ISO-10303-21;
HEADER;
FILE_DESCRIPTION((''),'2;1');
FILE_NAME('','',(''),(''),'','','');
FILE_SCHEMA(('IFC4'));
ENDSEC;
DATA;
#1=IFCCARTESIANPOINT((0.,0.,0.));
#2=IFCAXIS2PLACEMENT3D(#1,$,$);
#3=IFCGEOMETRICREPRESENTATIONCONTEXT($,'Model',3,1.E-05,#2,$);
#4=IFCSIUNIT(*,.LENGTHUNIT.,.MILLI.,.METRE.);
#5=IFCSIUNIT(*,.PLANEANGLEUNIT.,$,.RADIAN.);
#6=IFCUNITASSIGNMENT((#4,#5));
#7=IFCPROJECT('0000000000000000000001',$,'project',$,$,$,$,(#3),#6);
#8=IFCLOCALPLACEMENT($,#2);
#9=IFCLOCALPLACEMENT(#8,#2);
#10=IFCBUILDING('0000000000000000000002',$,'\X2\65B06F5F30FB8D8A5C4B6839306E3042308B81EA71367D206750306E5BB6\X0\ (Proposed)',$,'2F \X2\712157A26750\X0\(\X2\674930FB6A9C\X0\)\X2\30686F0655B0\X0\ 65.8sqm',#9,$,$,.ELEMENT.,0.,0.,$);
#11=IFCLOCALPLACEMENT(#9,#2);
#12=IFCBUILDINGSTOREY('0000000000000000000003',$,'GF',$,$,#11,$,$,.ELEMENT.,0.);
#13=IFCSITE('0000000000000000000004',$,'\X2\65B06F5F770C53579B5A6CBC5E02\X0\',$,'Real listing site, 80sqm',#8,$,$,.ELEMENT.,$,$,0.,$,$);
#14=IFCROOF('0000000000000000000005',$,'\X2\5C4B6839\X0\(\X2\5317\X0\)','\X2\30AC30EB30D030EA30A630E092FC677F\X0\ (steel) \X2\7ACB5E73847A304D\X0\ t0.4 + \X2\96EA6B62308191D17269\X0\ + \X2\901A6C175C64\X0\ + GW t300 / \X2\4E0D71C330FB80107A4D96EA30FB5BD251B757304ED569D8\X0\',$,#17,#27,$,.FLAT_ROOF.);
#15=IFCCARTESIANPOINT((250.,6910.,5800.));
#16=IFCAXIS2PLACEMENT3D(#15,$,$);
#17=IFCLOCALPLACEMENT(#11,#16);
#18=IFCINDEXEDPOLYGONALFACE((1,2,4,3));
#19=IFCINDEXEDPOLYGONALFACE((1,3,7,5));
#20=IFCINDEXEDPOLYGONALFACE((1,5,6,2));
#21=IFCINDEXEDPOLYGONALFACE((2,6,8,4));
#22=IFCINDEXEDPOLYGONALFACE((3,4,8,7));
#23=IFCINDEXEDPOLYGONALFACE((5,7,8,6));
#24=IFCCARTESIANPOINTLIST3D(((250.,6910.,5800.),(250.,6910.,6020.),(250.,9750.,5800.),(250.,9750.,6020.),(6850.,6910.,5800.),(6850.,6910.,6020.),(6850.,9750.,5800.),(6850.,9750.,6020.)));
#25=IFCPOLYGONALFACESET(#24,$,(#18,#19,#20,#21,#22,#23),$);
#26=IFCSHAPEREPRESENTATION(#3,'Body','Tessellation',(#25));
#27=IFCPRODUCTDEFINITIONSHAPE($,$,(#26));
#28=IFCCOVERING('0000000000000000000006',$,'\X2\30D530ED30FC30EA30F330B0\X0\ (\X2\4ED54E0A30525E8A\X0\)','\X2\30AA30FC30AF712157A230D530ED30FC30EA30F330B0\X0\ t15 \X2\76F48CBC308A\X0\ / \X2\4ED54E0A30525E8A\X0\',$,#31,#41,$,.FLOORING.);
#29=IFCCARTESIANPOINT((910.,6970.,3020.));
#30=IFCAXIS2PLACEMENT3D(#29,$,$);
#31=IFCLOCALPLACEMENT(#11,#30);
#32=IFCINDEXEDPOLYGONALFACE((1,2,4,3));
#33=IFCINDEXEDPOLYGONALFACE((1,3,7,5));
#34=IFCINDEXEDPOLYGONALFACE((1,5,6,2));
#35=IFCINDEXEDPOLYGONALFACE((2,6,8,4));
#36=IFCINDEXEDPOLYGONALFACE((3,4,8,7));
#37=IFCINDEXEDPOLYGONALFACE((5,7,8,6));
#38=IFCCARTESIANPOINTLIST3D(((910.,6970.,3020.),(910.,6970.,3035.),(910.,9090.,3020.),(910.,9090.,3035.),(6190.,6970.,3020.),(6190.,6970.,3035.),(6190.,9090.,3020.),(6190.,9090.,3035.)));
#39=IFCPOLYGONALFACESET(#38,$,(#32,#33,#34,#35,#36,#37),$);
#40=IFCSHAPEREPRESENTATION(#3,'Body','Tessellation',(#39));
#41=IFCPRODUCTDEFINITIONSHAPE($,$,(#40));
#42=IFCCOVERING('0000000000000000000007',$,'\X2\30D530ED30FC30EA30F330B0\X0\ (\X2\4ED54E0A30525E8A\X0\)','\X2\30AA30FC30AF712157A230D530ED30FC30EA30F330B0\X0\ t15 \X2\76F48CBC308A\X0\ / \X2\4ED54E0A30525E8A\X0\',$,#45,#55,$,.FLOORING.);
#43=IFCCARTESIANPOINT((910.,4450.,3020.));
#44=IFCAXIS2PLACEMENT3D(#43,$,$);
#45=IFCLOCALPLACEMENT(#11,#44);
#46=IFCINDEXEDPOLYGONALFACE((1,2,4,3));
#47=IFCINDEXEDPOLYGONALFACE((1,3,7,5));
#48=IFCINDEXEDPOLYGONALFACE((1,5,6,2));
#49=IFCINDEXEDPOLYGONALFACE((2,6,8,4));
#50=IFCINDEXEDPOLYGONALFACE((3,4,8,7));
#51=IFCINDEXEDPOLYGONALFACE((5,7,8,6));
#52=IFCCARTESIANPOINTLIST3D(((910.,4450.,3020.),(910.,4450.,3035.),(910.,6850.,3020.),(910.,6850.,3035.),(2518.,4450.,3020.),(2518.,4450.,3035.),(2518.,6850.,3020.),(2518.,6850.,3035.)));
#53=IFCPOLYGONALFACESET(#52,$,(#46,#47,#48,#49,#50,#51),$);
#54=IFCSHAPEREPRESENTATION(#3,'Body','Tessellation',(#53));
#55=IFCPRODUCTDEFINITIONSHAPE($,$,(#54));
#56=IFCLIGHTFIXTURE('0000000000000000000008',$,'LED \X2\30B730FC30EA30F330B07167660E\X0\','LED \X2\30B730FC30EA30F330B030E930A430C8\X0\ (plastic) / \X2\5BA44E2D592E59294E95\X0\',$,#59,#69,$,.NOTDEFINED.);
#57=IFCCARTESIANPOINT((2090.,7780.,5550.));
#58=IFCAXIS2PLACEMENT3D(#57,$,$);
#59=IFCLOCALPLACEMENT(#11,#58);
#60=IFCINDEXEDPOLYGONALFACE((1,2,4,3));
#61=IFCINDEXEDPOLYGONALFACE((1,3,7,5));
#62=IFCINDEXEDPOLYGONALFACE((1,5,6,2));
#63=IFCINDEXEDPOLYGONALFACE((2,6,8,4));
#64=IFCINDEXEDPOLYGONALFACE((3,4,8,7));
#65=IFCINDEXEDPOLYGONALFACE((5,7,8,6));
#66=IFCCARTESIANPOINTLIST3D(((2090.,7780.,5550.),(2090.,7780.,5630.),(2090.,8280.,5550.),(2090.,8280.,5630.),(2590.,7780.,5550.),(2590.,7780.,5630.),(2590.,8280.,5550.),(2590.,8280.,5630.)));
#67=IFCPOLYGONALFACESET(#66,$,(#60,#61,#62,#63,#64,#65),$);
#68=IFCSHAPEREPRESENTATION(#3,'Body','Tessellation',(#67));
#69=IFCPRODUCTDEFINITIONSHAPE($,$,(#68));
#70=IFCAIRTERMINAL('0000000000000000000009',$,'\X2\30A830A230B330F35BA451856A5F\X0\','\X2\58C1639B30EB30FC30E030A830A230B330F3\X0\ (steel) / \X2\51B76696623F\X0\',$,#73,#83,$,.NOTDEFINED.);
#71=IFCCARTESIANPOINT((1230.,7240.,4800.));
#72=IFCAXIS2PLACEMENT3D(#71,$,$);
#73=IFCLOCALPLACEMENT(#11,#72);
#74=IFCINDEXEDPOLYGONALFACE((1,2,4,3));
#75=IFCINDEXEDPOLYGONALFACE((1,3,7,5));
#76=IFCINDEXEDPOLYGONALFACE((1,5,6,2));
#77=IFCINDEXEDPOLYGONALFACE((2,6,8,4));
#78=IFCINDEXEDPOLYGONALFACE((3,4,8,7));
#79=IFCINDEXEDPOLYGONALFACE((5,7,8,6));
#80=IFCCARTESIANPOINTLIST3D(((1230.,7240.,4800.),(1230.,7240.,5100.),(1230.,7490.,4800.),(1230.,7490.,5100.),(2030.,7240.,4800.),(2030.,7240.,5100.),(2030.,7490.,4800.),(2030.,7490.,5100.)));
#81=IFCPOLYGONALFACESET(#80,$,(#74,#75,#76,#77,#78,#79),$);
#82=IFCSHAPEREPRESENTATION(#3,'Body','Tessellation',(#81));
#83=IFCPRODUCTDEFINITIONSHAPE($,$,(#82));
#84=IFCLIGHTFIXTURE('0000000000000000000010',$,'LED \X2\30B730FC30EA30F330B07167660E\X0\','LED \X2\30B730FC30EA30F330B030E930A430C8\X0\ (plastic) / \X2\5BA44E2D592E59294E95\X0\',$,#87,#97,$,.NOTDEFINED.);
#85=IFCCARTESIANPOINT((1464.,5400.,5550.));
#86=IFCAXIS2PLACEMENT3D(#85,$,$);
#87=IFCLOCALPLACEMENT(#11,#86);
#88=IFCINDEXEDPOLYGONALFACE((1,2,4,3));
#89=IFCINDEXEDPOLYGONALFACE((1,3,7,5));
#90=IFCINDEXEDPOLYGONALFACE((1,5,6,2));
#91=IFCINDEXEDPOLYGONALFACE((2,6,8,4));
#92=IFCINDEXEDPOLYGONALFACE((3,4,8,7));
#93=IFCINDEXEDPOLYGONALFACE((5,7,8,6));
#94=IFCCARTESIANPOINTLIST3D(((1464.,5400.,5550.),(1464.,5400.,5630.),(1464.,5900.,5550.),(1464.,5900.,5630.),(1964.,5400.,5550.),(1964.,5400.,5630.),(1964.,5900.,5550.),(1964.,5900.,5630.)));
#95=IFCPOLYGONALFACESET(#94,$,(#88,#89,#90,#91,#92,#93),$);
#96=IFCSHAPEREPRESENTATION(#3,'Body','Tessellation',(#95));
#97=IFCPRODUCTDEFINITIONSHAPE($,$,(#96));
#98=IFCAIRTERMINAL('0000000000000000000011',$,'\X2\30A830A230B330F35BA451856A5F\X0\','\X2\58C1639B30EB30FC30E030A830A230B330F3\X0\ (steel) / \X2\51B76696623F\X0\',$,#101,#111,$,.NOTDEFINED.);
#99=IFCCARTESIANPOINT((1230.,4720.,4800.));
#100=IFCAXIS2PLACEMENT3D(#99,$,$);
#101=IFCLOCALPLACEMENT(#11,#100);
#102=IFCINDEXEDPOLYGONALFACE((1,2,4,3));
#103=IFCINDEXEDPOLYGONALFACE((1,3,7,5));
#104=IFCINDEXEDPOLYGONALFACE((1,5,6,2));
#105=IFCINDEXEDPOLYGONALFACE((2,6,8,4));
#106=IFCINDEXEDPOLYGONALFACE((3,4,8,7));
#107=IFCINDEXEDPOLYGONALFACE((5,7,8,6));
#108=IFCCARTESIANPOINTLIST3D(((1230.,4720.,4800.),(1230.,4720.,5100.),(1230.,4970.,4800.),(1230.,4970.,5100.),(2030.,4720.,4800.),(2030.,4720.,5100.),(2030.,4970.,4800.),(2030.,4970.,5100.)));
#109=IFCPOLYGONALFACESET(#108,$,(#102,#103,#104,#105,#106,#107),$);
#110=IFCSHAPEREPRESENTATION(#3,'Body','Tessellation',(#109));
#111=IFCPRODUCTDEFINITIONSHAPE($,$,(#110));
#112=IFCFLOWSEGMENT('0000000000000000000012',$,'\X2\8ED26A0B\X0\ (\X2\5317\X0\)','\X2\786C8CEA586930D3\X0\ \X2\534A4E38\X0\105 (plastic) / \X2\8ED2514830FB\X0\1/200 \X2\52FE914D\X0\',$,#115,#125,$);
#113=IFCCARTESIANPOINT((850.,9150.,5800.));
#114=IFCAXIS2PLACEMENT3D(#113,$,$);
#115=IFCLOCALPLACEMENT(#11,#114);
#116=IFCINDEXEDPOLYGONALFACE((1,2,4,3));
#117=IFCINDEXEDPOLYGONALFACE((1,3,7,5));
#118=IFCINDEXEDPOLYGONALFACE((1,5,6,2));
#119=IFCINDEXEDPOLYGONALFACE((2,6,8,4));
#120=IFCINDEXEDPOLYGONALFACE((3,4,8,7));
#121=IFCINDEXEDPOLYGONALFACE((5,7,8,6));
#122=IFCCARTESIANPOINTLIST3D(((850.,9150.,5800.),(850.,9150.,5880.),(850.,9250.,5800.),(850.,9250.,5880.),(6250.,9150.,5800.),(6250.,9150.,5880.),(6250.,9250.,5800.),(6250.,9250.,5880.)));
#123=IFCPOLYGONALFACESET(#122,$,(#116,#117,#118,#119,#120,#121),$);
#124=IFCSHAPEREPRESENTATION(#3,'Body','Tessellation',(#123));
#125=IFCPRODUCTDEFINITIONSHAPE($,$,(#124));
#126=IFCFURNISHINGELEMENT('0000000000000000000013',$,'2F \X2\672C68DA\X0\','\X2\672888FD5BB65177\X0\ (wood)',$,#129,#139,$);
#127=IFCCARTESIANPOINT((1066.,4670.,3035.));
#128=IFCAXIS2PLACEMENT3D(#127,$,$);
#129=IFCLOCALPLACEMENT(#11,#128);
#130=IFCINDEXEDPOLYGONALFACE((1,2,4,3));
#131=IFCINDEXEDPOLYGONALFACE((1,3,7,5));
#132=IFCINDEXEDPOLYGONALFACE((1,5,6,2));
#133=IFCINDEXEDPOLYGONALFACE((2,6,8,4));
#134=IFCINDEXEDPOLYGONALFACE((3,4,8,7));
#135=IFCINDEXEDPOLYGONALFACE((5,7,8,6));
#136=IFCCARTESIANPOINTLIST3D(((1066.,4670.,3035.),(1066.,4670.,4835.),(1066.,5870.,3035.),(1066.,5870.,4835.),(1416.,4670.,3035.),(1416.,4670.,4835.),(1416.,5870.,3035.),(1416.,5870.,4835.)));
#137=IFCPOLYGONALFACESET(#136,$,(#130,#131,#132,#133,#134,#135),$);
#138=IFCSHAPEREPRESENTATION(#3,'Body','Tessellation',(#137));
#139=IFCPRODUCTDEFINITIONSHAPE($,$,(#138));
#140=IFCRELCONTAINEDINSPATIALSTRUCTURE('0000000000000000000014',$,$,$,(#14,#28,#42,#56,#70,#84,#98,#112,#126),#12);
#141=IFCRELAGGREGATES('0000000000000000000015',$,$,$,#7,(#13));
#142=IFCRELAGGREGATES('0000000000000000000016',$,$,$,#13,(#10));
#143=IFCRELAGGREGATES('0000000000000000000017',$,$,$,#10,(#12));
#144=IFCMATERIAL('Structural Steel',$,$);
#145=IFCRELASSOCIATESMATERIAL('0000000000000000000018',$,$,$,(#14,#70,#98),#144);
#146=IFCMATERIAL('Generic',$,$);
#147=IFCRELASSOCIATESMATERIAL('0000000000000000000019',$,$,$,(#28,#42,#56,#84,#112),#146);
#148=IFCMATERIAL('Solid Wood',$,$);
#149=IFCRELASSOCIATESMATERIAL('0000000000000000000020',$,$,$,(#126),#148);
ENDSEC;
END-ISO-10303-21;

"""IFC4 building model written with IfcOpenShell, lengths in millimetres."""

from ifc_helpers import new_model, si_unit, frame, frame_2d, origin, place, context, project, spatial, rectangle, extrude, material, element, save


model = new_model("IFC4")

# Units and contexts
model_context = context("Model", 3, precision=1e-05, world=origin())
ifc_project = project(units=[si_unit("LENGTHUNIT", "METRE", prefix="MILLI"), si_unit("PLANEANGLEUNIT", "RADIAN")], contexts=[model_context])

# Site, building, storey
site_placement = place(None, origin())
site = spatial("IfcSite", under=ifc_project, at=site_placement, Name="新潟県南魚沼市", ObjectType="Real listing site, 80sqm", CompositionType="ELEMENT", RefElevation=0.0)
building_placement = place(site_placement, origin())
building = spatial("IfcBuilding", under=site, at=building_placement, Name="新潟・越屋根のある自然素材の家 (Proposed)", ObjectType="2F 無垢材(杉・檜)と漆喰 65.8sqm", CompositionType="ELEMENT", ElevationOfRefHeight=0.0, ElevationOfTerrain=0.0)
storey_placement = place(building_placement, origin())
storey = spatial("IfcBuildingStorey", under=building, at=storey_placement, Name="GF", CompositionType="ELEMENT", Elevation=0.0)

# Shared definitions
ifc_material_1 = material(Name="Solid Wood")

# Roof
ifc_material_2 = material(Name="Structural Steel")
for number, where, name in (
    (1, (250.0, 6910.0, 5800.0), "屋根(北)"),
):
    element("IfcRoof", number, at=place(storey_placement, frame(where)), inside=storey, material=ifc_material_2, Name=name, Description="ガルバリウム鋼板 (steel) 立平葺き t0.4 + 雪止め金物 + 通気層 + GW t300 / 不燃・耐積雪・寒冷地仕様", PredefinedType="FLAT_ROOF", context=model_context, shape_type="SweptSolid", body=[
        extrude(rectangle(XDim=6600.0, YDim=2840.0, at=frame_2d((3300.0, 1420.0))), frame((250.0, 6910.0, 5800.0)), (0.0, 0.0, 1.0), 220.0),
    ])

# Coverings
ifc_material_3 = material(Name="Generic")
covering_1_placement = place(storey_placement, frame((910.0, 6970.0, 3020.0)))
element("IfcCovering", 2, at=covering_1_placement, inside=storey, material=ifc_material_3, Name="フローリング (仕上げ床)", Description="オーク無垢フローリング t15 直貼り / 仕上げ床", PredefinedType="FLOORING", context=model_context, shape_type="SweptSolid", body=[
    extrude(rectangle(XDim=5280.0, YDim=2120.0, at=frame_2d((2640.0, 1060.0))), frame((910.0, 6970.0, 3020.0)), (0.0, 0.0, 1.0), 15.0),
])
covering_2_placement = place(storey_placement, frame((910.0, 4450.0, 3020.0)))
element("IfcCovering", 3, at=covering_2_placement, inside=storey, material=ifc_material_3, Name="フローリング (仕上げ床)", Description="オーク無垢フローリング t15 直貼り / 仕上げ床", PredefinedType="FLOORING", context=model_context, shape_type="SweptSolid", body=[
    extrude(rectangle(XDim=1608.0, YDim=2400.0, at=frame_2d((804.0, 1200.0))), frame((910.0, 4450.0, 3020.0)), (0.0, 0.0, 1.0), 15.0),
])

# Light fixture
light_fixture_1_placement = place(storey_placement, frame((2090.0, 7780.0, 5550.0)))
element("IfcLightFixture", 4, at=light_fixture_1_placement, inside=storey, material=ifc_material_3, Name="LED シーリング照明", Description="LED シーリングライト (plastic) / 室中央天井", PredefinedType="NOTDEFINED", context=model_context, shape_type="SweptSolid", body=[
    extrude(rectangle(XDim=500.0, YDim=500.0, at=frame_2d((250.0, 250.0))), frame((2090.0, 7780.0, 5550.0)), (0.0, 0.0, 1.0), 80.0),
])

# Air terminal
air_terminal_1_placement = place(storey_placement, frame((1230.0, 7240.0, 4800.0)))
element("IfcAirTerminal", 5, at=air_terminal_1_placement, inside=storey, material=ifc_material_2, Name="エアコン室内機", Description="壁掛ルームエアコン (steel) / 冷暖房", PredefinedType="NOTDEFINED", context=model_context, shape_type="SweptSolid", body=[
    extrude(rectangle(XDim=800.0, YDim=250.0, at=frame_2d((400.0, 125.0))), frame((1230.0, 7240.0, 4800.0)), (0.0, 0.0, 1.0), 300.0),
])

# Light fixture
light_fixture_2_placement = place(storey_placement, frame((1464.0, 5400.0, 5550.0)))
element("IfcLightFixture", 6, at=light_fixture_2_placement, inside=storey, material=ifc_material_3, Name="LED シーリング照明", Description="LED シーリングライト (plastic) / 室中央天井", PredefinedType="NOTDEFINED", context=model_context, shape_type="SweptSolid", body=[
    extrude(rectangle(XDim=500.0, YDim=500.0, at=frame_2d((250.0, 250.0))), frame((1464.0, 5400.0, 5550.0)), (0.0, 0.0, 1.0), 80.0),
])

# Air terminal
air_terminal_2_placement = place(storey_placement, frame((1230.0, 4720.0, 4800.0)))
element("IfcAirTerminal", 7, at=air_terminal_2_placement, inside=storey, material=ifc_material_2, Name="エアコン室内機", Description="壁掛ルームエアコン (steel) / 冷暖房", PredefinedType="NOTDEFINED", context=model_context, shape_type="SweptSolid", body=[
    extrude(rectangle(XDim=800.0, YDim=250.0, at=frame_2d((400.0, 125.0))), frame((1230.0, 4720.0, 4800.0)), (0.0, 0.0, 1.0), 300.0),
])

# Flow segment
flow_segment_placement = place(storey_placement, frame((850.0, 9150.0, 5800.0)))
element("IfcFlowSegment", 8, at=flow_segment_placement, inside=storey, material=ifc_material_3, Name="軒樋 (北)", Description="硬質塩ビ 半丸105 (plastic) / 軒先・1/200 勾配", context=model_context, shape_type="SweptSolid", body=[
    extrude(rectangle(XDim=5400.0, YDim=100.0, at=frame_2d((2700.0, 50.0))), frame((850.0, 9150.0, 5800.0)), (0.0, 0.0, 1.0), 80.0),
])

# Furnishing element
furnishing_placement = place(storey_placement, frame((1066.0, 4670.0, 3035.0)))
element("IfcFurnishingElement", 9, at=furnishing_placement, inside=storey, material=ifc_material_1, Name="2F 本棚", Description="木製家具 (wood)", context=model_context, shape_type="SweptSolid", body=[
    extrude(rectangle(XDim=350.0, YDim=1200.0, at=frame_2d((175.0, 600.0))), frame((1066.0, 4670.0, 3035.0)), (0.0, 0.0, 1.0), 1800.0),
])

save(model, "model.ifc")
